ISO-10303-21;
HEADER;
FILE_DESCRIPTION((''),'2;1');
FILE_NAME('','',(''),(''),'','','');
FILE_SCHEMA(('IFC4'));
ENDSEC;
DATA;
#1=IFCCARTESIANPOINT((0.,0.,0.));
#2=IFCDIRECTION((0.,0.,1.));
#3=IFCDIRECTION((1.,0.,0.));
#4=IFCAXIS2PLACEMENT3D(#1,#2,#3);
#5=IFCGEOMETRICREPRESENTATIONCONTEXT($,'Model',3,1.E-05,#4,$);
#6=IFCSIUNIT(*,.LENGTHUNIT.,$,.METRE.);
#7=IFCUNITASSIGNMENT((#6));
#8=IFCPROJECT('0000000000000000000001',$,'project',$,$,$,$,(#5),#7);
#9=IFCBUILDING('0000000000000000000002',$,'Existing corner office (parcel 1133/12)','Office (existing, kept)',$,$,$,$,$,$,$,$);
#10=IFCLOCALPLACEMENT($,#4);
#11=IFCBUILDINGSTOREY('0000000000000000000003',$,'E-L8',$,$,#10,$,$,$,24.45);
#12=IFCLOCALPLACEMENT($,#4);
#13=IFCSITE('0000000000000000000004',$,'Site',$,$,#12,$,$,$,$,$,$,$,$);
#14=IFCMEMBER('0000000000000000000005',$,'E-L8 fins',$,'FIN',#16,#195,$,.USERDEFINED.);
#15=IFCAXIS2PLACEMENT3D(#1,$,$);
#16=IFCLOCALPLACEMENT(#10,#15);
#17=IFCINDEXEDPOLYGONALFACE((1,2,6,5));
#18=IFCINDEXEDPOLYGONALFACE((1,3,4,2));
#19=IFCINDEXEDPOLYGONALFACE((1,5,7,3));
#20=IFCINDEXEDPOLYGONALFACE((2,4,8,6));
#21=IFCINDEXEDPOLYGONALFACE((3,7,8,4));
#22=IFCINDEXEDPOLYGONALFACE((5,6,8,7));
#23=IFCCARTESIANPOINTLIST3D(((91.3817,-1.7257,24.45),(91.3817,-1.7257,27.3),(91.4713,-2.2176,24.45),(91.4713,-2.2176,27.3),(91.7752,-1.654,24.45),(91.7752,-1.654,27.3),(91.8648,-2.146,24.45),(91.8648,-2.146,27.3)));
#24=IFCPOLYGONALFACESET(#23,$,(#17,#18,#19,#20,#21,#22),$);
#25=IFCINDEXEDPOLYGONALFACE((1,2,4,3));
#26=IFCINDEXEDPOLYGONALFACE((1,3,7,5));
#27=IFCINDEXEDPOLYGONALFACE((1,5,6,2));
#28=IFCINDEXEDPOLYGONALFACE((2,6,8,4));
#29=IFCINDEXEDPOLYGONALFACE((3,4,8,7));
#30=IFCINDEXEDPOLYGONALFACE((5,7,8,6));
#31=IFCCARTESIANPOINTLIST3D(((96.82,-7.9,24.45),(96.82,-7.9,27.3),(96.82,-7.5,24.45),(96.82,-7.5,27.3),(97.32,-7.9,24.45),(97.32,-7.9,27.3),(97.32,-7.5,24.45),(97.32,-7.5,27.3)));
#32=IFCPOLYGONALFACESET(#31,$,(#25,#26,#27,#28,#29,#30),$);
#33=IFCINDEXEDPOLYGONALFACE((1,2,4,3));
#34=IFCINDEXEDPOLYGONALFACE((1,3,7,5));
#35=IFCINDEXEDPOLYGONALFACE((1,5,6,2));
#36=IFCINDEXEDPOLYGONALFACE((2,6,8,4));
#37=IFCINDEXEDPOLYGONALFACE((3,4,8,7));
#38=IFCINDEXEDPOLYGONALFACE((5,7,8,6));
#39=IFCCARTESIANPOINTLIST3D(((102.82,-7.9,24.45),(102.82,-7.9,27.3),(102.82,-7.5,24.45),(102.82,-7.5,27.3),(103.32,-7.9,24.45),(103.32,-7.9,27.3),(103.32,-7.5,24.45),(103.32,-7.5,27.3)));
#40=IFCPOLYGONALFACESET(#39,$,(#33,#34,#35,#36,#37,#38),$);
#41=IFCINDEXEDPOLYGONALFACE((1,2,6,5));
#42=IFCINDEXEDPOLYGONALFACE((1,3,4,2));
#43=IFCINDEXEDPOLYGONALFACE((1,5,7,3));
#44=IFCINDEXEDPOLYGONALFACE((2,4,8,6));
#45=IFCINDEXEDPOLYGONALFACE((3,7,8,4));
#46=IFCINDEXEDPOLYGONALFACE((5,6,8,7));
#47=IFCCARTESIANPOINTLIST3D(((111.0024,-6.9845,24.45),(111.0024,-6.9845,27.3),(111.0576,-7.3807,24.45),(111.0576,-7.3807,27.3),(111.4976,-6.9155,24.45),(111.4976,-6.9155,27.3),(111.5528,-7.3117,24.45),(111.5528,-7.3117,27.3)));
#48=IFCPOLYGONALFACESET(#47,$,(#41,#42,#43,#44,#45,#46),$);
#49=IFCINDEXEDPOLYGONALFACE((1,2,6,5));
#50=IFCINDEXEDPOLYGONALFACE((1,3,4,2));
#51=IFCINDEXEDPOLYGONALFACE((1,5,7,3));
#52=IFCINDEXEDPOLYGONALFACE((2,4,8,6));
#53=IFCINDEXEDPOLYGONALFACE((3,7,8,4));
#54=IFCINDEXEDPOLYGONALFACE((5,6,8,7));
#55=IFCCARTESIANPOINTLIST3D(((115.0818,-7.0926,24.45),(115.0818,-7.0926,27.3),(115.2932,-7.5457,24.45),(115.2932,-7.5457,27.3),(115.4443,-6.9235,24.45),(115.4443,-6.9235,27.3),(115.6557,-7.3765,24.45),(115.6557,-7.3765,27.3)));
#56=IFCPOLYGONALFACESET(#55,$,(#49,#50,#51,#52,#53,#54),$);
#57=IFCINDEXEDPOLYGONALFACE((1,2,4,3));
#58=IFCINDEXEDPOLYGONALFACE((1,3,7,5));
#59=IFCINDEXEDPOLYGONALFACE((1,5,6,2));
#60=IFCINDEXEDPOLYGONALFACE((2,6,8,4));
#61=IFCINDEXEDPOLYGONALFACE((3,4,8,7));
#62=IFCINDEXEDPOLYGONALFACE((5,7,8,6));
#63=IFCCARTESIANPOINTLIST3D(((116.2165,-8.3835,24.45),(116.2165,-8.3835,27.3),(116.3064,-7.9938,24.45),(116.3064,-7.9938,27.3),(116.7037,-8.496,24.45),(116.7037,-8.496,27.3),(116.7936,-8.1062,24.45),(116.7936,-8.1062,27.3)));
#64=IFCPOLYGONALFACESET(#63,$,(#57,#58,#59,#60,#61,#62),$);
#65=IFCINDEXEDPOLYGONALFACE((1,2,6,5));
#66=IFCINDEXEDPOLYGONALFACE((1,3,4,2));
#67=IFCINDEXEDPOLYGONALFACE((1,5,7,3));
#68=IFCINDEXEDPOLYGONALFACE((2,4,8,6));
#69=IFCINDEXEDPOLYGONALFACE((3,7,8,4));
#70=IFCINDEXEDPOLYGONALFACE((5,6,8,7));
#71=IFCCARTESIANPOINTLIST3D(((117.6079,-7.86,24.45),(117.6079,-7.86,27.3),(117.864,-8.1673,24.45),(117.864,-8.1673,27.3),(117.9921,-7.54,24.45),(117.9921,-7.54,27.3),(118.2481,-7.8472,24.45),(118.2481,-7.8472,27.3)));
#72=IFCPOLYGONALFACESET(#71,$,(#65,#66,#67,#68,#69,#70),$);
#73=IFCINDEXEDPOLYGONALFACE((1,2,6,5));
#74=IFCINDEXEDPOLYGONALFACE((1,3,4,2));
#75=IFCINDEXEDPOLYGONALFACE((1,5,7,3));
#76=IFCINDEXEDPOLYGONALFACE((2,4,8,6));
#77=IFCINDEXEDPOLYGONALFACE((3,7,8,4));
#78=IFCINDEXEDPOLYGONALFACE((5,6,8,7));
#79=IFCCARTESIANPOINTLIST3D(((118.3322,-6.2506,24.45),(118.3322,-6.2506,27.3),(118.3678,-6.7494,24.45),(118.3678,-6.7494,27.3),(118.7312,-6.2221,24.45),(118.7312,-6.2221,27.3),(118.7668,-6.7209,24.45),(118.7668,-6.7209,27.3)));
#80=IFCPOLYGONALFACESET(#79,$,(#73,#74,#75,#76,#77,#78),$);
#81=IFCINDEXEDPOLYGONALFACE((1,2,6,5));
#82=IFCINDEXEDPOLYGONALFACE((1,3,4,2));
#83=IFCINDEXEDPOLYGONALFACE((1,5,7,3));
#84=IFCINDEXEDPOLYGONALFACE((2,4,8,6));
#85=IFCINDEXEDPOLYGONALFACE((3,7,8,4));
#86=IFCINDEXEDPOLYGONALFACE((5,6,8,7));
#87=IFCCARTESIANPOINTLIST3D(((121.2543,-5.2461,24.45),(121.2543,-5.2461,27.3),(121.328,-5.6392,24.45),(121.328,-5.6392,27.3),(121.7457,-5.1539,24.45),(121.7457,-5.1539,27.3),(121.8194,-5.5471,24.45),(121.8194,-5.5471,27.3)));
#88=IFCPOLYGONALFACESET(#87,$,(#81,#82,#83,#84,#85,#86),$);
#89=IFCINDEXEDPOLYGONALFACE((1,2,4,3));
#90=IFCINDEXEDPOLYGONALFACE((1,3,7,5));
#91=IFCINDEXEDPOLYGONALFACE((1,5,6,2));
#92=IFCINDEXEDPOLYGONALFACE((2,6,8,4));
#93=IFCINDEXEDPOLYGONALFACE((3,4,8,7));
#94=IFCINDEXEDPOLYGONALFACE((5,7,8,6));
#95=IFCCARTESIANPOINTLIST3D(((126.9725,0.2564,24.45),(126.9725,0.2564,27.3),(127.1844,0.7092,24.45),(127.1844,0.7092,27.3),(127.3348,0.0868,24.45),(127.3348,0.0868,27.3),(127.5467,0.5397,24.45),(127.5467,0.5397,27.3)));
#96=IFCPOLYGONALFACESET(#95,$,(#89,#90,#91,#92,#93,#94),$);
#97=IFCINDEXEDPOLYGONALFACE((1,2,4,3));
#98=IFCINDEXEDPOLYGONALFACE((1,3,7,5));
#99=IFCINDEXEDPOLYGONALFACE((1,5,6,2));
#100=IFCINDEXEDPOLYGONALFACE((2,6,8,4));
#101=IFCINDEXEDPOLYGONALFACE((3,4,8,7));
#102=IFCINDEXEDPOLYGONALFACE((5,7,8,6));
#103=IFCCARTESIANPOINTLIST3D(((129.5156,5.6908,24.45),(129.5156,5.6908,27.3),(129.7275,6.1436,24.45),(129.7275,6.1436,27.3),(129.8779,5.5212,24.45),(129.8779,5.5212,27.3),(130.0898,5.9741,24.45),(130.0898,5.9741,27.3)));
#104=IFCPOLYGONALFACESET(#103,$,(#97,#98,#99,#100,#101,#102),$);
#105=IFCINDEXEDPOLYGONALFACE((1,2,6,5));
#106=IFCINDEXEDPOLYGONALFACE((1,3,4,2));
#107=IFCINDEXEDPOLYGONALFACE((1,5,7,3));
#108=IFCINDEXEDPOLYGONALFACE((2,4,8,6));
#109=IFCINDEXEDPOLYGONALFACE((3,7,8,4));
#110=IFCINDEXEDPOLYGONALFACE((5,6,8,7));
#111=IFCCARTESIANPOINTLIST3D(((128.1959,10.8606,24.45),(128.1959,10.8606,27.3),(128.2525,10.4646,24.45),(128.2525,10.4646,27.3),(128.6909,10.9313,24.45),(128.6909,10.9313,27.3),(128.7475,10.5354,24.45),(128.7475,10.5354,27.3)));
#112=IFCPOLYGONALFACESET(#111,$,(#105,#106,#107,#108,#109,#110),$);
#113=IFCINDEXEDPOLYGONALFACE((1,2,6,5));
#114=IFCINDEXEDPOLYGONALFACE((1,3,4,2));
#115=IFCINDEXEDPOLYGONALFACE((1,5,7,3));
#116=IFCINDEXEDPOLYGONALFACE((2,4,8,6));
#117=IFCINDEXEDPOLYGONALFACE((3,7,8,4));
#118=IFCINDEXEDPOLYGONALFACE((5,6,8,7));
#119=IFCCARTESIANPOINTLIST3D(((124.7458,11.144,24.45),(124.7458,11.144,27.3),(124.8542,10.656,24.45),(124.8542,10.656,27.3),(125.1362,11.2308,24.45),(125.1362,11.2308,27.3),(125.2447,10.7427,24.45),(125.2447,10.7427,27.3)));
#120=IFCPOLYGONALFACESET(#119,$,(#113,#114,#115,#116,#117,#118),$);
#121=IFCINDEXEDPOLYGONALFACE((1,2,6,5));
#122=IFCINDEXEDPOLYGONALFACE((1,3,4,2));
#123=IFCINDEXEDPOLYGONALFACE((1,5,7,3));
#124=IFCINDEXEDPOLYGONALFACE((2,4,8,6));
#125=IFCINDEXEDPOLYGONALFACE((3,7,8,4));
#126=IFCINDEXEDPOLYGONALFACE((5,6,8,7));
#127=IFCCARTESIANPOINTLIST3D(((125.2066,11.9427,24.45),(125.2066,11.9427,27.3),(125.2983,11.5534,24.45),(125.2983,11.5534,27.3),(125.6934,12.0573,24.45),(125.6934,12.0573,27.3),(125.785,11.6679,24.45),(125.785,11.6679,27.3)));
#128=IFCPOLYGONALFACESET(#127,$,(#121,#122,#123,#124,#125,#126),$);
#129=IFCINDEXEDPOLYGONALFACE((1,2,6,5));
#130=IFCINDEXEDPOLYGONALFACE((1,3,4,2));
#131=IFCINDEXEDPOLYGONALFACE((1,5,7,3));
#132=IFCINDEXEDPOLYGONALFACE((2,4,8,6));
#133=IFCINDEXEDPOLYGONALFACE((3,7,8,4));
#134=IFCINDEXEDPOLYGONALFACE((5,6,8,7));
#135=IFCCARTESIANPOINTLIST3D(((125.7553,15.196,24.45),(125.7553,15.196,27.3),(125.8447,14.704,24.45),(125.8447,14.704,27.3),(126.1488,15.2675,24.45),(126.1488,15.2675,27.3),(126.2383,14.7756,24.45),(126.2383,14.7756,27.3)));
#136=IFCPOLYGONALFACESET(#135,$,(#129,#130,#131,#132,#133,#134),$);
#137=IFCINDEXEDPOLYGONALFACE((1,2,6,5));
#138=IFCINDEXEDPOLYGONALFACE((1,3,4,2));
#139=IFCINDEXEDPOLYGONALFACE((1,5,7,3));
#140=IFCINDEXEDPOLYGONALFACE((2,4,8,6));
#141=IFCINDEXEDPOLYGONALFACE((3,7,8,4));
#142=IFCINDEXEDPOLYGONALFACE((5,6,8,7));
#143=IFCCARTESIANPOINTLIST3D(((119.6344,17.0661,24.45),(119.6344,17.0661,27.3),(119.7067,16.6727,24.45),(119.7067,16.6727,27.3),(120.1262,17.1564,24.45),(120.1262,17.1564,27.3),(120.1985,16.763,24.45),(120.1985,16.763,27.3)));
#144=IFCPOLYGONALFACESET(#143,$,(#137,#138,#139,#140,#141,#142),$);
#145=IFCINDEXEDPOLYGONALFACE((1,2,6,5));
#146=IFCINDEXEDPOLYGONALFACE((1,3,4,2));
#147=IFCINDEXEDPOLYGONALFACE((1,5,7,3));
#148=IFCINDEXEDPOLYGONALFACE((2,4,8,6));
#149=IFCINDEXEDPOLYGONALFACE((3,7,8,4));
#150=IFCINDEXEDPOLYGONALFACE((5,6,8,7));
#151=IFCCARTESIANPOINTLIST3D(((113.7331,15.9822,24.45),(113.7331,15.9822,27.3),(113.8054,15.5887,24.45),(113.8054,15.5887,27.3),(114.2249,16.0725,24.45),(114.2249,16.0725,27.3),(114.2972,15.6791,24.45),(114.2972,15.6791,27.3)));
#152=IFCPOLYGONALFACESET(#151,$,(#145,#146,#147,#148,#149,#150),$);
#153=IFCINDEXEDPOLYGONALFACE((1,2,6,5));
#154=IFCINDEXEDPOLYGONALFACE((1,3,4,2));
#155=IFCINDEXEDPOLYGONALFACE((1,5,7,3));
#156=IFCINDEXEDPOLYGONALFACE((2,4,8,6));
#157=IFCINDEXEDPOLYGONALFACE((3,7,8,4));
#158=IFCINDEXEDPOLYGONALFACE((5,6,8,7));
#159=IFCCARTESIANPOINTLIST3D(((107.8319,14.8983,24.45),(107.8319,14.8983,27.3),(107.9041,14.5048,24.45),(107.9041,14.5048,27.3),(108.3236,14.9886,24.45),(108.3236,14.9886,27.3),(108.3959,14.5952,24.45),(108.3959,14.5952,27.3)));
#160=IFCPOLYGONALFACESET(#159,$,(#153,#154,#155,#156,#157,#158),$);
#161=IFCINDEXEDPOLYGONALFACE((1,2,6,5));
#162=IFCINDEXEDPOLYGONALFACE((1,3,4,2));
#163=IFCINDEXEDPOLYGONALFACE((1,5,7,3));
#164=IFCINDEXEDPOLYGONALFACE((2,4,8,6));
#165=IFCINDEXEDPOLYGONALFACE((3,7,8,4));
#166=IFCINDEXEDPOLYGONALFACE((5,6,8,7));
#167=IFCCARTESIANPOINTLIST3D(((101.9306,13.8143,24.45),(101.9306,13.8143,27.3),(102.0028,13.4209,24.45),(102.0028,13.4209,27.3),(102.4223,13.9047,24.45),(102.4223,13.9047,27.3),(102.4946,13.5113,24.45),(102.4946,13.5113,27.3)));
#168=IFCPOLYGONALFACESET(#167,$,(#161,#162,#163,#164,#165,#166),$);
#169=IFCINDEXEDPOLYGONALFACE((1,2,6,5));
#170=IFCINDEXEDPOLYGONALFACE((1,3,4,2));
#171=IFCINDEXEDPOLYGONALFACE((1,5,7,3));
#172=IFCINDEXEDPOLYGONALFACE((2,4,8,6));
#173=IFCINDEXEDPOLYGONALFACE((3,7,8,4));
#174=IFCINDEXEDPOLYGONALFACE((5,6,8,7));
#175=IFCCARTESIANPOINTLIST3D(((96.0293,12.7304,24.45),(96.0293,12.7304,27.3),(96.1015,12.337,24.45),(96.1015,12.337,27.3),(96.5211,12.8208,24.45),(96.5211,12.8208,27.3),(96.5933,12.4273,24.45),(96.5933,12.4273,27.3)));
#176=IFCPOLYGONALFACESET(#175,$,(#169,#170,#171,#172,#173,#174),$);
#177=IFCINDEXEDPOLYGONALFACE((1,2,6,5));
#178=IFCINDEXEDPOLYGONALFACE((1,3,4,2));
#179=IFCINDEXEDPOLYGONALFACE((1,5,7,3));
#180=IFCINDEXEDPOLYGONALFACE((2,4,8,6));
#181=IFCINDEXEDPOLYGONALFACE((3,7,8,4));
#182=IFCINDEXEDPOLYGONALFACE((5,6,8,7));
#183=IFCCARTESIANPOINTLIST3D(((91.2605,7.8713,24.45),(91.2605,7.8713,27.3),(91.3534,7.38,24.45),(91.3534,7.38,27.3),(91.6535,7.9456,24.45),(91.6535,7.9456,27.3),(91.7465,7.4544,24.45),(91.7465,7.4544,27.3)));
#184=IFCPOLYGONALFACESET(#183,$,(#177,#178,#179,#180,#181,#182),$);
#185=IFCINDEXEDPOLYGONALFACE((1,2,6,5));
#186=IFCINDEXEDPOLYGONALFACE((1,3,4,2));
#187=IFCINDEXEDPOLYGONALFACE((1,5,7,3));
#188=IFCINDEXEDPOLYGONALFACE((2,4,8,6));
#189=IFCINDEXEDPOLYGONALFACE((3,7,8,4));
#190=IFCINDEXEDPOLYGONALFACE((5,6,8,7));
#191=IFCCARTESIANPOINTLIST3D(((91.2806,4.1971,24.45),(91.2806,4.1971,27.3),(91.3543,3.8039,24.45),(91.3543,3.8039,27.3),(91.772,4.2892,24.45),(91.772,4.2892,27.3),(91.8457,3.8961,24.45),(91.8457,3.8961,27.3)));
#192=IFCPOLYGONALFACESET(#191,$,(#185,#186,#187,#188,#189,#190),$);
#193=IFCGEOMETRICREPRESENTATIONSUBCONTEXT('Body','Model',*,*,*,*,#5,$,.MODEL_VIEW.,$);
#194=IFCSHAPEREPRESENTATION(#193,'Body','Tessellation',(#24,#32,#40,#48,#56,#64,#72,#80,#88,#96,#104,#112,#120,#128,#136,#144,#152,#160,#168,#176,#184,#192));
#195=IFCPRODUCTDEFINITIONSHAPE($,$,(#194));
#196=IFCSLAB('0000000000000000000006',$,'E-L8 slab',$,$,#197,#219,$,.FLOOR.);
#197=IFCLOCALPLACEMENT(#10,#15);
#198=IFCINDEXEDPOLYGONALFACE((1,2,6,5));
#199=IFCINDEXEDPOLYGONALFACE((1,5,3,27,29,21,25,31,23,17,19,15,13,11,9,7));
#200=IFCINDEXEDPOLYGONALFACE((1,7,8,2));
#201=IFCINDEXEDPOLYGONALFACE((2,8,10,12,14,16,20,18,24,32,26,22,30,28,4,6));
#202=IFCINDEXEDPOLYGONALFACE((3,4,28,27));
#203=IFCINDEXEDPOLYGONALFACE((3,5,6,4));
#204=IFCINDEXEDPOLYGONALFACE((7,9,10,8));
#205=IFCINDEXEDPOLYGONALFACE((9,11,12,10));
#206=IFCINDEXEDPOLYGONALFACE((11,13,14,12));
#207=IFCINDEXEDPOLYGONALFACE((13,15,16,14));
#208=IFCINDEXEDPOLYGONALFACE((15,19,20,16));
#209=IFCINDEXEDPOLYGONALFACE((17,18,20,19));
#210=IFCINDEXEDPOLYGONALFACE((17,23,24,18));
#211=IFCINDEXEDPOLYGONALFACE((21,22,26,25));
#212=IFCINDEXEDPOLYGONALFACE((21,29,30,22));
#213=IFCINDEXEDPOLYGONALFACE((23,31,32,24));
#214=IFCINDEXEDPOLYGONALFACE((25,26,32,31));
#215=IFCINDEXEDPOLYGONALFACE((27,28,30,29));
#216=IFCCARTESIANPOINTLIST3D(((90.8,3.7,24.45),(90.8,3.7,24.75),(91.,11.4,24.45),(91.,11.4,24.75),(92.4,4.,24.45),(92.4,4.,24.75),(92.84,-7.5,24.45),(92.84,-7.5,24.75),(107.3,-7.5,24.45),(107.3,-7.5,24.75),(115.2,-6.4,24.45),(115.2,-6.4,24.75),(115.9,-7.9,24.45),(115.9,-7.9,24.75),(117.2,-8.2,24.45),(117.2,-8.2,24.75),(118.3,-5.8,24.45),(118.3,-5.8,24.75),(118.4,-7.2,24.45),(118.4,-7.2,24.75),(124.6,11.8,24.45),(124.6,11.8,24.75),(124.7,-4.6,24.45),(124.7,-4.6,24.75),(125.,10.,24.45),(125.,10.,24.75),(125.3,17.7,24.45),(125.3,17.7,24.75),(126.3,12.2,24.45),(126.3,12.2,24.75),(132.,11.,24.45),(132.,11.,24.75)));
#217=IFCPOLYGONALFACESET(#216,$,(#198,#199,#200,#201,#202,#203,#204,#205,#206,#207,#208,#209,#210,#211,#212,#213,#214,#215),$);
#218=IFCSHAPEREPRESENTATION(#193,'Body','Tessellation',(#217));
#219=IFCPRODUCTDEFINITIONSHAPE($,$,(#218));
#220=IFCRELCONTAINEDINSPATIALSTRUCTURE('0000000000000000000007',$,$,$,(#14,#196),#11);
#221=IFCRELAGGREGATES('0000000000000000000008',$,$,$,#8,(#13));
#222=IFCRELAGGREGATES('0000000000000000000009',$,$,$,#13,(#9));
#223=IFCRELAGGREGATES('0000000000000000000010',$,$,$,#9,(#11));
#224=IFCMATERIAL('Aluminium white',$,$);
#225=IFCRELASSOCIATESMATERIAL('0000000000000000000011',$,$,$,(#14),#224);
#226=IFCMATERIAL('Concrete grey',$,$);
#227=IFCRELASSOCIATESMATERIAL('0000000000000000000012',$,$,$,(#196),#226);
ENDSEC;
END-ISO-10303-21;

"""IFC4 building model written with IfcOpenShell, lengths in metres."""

from ifc_helpers import new_model, si_unit, frame, origin_with_axes, place, context, subcontext, project, spatial, polyline, outline, extrude, material, element, save


model = new_model("IFC4")

# Units and contexts
model_context = context("Model", 3, precision=1e-05, world=origin_with_axes())
body_context = subcontext(model_context, "Body", "Model", "MODEL_VIEW")
ifc_project = project(units=[si_unit("LENGTHUNIT", "METRE")], contexts=[model_context])

# Site, building, storey
site_placement = place(None, origin_with_axes())
site = spatial("IfcSite", under=ifc_project, at=site_placement, Name="Site")
building = spatial("IfcBuilding", under=site, Name="Existing corner office (parcel 1133/12)", Description="Office (existing, kept)")
storey_placement = place(None, origin_with_axes())
storey = spatial("IfcBuildingStorey", under=building, at=storey_placement, Name="E-L8", Elevation=24.45)

# Member
ifc_material_1 = material(Name="Aluminium white")
member_1_placement = place(storey_placement, origin_with_axes())
element("IfcMember", 1, at=member_1_placement, inside=storey, material=ifc_material_1, Name="E-L8 fins", ObjectType="FIN", PredefinedType="USERDEFINED", context=body_context, shape_type="SweptSolid", body=[
    extrude(outline(polyline([(-0.2, -0.25), (0.2, -0.25), (0.2, 0.25), (-0.2, 0.25), (-0.2, -0.25)])), frame((91.6232, -1.9358, 24.45), z_axis=(0.0, 0.0, 1.0), x_axis=(-0.983814, -0.179195, 0.0)), (0.0, 0.0, 1.0), 2.85),
    extrude(outline(polyline([(-0.2, -0.25), (0.2, -0.25), (0.2, 0.25), (-0.2, 0.25), (-0.2, -0.25)])), frame((97.07, -7.7, 24.45), z_axis=(0.0, 0.0, 1.0), x_axis=(0.0, -1.0, 0.0)), (0.0, 0.0, 1.0), 2.85),
    extrude(outline(polyline([(-0.2, -0.25), (0.2, -0.25), (0.2, 0.25), (-0.2, 0.25), (-0.2, -0.25)])), frame((103.07, -7.7, 24.45), z_axis=(0.0, 0.0, 1.0), x_axis=(0.0, -1.0, 0.0)), (0.0, 0.0, 1.0), 2.85),
    extrude(outline(polyline([(-0.2, -0.25), (0.2, -0.25), (0.2, 0.25), (-0.2, 0.25), (-0.2, -0.25)])), frame((111.2776, -7.1481, 24.45), z_axis=(0.0, 0.0, 1.0), x_axis=(0.13791, -0.990445, 0.0)), (0.0, 0.0, 1.0), 2.85),
    extrude(outline(polyline([(-0.2, -0.25), (0.2, -0.25), (0.2, 0.25), (-0.2, 0.25), (-0.2, -0.25)])), frame((115.3688, -7.2346, 24.45), z_axis=(0.0, 0.0, 1.0), x_axis=(-0.906183, -0.422885, 0.0)), (0.0, 0.0, 1.0), 2.85),
    extrude(outline(polyline([(-0.2, -0.25), (0.2, -0.25), (0.2, 0.25), (-0.2, 0.25), (-0.2, -0.25)])), frame((116.505, -8.2449, 24.45), z_axis=(0.0, 0.0, 1.0), x_axis=(-0.22486, -0.974391, 0.0)), (0.0, 0.0, 1.0), 2.85),
    extrude(outline(polyline([(-0.2, -0.25), (0.2, -0.25), (0.2, 0.25), (-0.2, 0.25), (-0.2, -0.25)])), frame((117.928, -7.8536, 24.45), z_axis=(0.0, 0.0, 1.0), x_axis=(0.640184, -0.768221, 0.0)), (0.0, 0.0, 1.0), 2.85),
    extrude(outline(polyline([(-0.2, -0.25), (0.2, -0.25), (0.2, 0.25), (-0.2, 0.25), (-0.2, -0.25)])), frame((118.5495, -6.4858, 24.45), z_axis=(0.0, 0.0, 1.0), x_axis=(0.997459, 0.071247, 0.0)), (0.0, 0.0, 1.0), 2.85),
    extrude(outline(polyline([(-0.2, -0.25), (0.2, -0.25), (0.2, 0.25), (-0.2, 0.25), (-0.2, -0.25)])), frame((121.5369, -5.3966, 24.45), z_axis=(0.0, 0.0, 1.0), x_axis=(0.184289, -0.982872, 0.0)), (0.0, 0.0, 1.0), 2.85),
    extrude(outline(polyline([(-0.2, -0.25), (0.2, -0.25), (0.2, 0.25), (-0.2, 0.25), (-0.2, -0.25)])), frame((127.2596, 0.398, 24.45), z_axis=(0.0, 0.0, 1.0), x_axis=(0.905738, -0.423839, 0.0)), (0.0, 0.0, 1.0), 2.85),
    extrude(outline(polyline([(-0.2, -0.25), (0.2, -0.25), (0.2, 0.25), (-0.2, 0.25), (-0.2, -0.25)])), frame((129.8027, 5.8324, 24.45), z_axis=(0.0, 0.0, 1.0), x_axis=(0.905738, -0.423839, 0.0)), (0.0, 0.0, 1.0), 2.85),
    extrude(outline(polyline([(-0.2, -0.25), (0.2, -0.25), (0.2, 0.25), (-0.2, 0.25), (-0.2, -0.25)])), frame((128.4717, 10.698, 24.45), z_axis=(0.0, 0.0, 1.0), x_axis=(-0.141421, 0.989949, 0.0)), (0.0, 0.0, 1.0), 2.85),
    extrude(outline(polyline([(-0.2, -0.25), (0.2, -0.25), (0.2, 0.25), (-0.2, 0.25), (-0.2, -0.25)])), frame((124.9952, 10.9434, 24.45), z_axis=(0.0, 0.0, 1.0), x_axis=(0.976187, 0.21693, 0.0)), (0.0, 0.0, 1.0), 2.85),
    extrude(outline(polyline([(-0.2, -0.25), (0.2, -0.25), (0.2, 0.25), (-0.2, 0.25), (-0.2, -0.25)])), frame((125.4958, 11.8053, 24.45), z_axis=(0.0, 0.0, 1.0), x_axis=(0.229039, -0.973417, 0.0)), (0.0, 0.0, 1.0), 2.85),
    extrude(outline(polyline([(-0.2, -0.25), (0.2, -0.25), (0.2, 0.25), (-0.2, 0.25), (-0.2, -0.25)])), frame((125.9968, 14.9858, 24.45), z_axis=(0.0, 0.0, 1.0), x_axis=(0.98387, 0.178885, 0.0)), (0.0, 0.0, 1.0), 2.85),
    extrude(outline(polyline([(-0.2, -0.25), (0.2, -0.25), (0.2, 0.25), (-0.2, 0.25), (-0.2, -0.25)])), frame((119.9164, 16.9145, 24.45), z_axis=(0.0, 0.0, 1.0), x_axis=(-0.180652, 0.983547, 0.0)), (0.0, 0.0, 1.0), 2.85),
    extrude(outline(polyline([(-0.2, -0.25), (0.2, -0.25), (0.2, 0.25), (-0.2, 0.25), (-0.2, -0.25)])), frame((114.0152, 15.8306, 24.45), z_axis=(0.0, 0.0, 1.0), x_axis=(-0.180652, 0.983547, 0.0)), (0.0, 0.0, 1.0), 2.85),
    extrude(outline(polyline([(-0.2, -0.25), (0.2, -0.25), (0.2, 0.25), (-0.2, 0.25), (-0.2, -0.25)])), frame((108.1139, 14.7467, 24.45), z_axis=(0.0, 0.0, 1.0), x_axis=(-0.180652, 0.983547, 0.0)), (0.0, 0.0, 1.0), 2.85),
    extrude(outline(polyline([(-0.2, -0.25), (0.2, -0.25), (0.2, 0.25), (-0.2, 0.25), (-0.2, -0.25)])), frame((102.2126, 13.6628, 24.45), z_axis=(0.0, 0.0, 1.0), x_axis=(-0.180652, 0.983547, 0.0)), (0.0, 0.0, 1.0), 2.85),
    extrude(outline(polyline([(-0.2, -0.25), (0.2, -0.25), (0.2, 0.25), (-0.2, 0.25), (-0.2, -0.25)])), frame((96.3113, 12.5789, 24.45), z_axis=(0.0, 0.0, 1.0), x_axis=(-0.180652, 0.983547, 0.0)), (0.0, 0.0, 1.0), 2.85),
    extrude(outline(polyline([(-0.2, -0.25), (0.2, -0.25), (0.2, 0.25), (-0.2, 0.25), (-0.2, -0.25)])), frame((91.5035, 7.6628, 24.45), z_axis=(0.0, 0.0, 1.0), x_axis=(-0.98257, -0.185892, 0.0)), (0.0, 0.0, 1.0), 2.85),
    extrude(outline(polyline([(-0.2, -0.25), (0.2, -0.25), (0.2, 0.25), (-0.2, 0.25), (-0.2, -0.25)])), frame((91.5631, 4.0466, 24.45), z_axis=(0.0, 0.0, 1.0), x_axis=(-0.184289, 0.982872, 0.0)), (0.0, 0.0, 1.0), 2.85),
])

# Slab
ifc_material_2 = material(Name="Concrete grey")
slab_1_placement = place(storey_placement, origin_with_axes())
element("IfcSlab", 2, at=slab_1_placement, inside=storey, material=ifc_material_2, Name="E-L8 slab", PredefinedType="FLOOR", context=body_context, shape_type="SweptSolid", body=[
    extrude(outline(polyline([(90.8, 3.7), (92.84, -7.5), (107.3, -7.5), (115.2, -6.4), (115.9, -7.9), (117.2, -8.2), (118.4, -7.2), (118.3, -5.8), (124.7, -4.6), (132.0, 11.0), (125.0, 10.0), (124.6, 11.8), (126.3, 12.2), (125.3, 17.7), (91.0, 11.4), (92.4, 4.0), (90.8, 3.7)])), frame((0.0, 0.0, 24.45), z_axis=(0.0, 0.0, 1.0), x_axis=(1.0, 0.0, 0.0)), (0.0, 0.0, 1.0), 0.3),
])

save(model, "model.ifc")
